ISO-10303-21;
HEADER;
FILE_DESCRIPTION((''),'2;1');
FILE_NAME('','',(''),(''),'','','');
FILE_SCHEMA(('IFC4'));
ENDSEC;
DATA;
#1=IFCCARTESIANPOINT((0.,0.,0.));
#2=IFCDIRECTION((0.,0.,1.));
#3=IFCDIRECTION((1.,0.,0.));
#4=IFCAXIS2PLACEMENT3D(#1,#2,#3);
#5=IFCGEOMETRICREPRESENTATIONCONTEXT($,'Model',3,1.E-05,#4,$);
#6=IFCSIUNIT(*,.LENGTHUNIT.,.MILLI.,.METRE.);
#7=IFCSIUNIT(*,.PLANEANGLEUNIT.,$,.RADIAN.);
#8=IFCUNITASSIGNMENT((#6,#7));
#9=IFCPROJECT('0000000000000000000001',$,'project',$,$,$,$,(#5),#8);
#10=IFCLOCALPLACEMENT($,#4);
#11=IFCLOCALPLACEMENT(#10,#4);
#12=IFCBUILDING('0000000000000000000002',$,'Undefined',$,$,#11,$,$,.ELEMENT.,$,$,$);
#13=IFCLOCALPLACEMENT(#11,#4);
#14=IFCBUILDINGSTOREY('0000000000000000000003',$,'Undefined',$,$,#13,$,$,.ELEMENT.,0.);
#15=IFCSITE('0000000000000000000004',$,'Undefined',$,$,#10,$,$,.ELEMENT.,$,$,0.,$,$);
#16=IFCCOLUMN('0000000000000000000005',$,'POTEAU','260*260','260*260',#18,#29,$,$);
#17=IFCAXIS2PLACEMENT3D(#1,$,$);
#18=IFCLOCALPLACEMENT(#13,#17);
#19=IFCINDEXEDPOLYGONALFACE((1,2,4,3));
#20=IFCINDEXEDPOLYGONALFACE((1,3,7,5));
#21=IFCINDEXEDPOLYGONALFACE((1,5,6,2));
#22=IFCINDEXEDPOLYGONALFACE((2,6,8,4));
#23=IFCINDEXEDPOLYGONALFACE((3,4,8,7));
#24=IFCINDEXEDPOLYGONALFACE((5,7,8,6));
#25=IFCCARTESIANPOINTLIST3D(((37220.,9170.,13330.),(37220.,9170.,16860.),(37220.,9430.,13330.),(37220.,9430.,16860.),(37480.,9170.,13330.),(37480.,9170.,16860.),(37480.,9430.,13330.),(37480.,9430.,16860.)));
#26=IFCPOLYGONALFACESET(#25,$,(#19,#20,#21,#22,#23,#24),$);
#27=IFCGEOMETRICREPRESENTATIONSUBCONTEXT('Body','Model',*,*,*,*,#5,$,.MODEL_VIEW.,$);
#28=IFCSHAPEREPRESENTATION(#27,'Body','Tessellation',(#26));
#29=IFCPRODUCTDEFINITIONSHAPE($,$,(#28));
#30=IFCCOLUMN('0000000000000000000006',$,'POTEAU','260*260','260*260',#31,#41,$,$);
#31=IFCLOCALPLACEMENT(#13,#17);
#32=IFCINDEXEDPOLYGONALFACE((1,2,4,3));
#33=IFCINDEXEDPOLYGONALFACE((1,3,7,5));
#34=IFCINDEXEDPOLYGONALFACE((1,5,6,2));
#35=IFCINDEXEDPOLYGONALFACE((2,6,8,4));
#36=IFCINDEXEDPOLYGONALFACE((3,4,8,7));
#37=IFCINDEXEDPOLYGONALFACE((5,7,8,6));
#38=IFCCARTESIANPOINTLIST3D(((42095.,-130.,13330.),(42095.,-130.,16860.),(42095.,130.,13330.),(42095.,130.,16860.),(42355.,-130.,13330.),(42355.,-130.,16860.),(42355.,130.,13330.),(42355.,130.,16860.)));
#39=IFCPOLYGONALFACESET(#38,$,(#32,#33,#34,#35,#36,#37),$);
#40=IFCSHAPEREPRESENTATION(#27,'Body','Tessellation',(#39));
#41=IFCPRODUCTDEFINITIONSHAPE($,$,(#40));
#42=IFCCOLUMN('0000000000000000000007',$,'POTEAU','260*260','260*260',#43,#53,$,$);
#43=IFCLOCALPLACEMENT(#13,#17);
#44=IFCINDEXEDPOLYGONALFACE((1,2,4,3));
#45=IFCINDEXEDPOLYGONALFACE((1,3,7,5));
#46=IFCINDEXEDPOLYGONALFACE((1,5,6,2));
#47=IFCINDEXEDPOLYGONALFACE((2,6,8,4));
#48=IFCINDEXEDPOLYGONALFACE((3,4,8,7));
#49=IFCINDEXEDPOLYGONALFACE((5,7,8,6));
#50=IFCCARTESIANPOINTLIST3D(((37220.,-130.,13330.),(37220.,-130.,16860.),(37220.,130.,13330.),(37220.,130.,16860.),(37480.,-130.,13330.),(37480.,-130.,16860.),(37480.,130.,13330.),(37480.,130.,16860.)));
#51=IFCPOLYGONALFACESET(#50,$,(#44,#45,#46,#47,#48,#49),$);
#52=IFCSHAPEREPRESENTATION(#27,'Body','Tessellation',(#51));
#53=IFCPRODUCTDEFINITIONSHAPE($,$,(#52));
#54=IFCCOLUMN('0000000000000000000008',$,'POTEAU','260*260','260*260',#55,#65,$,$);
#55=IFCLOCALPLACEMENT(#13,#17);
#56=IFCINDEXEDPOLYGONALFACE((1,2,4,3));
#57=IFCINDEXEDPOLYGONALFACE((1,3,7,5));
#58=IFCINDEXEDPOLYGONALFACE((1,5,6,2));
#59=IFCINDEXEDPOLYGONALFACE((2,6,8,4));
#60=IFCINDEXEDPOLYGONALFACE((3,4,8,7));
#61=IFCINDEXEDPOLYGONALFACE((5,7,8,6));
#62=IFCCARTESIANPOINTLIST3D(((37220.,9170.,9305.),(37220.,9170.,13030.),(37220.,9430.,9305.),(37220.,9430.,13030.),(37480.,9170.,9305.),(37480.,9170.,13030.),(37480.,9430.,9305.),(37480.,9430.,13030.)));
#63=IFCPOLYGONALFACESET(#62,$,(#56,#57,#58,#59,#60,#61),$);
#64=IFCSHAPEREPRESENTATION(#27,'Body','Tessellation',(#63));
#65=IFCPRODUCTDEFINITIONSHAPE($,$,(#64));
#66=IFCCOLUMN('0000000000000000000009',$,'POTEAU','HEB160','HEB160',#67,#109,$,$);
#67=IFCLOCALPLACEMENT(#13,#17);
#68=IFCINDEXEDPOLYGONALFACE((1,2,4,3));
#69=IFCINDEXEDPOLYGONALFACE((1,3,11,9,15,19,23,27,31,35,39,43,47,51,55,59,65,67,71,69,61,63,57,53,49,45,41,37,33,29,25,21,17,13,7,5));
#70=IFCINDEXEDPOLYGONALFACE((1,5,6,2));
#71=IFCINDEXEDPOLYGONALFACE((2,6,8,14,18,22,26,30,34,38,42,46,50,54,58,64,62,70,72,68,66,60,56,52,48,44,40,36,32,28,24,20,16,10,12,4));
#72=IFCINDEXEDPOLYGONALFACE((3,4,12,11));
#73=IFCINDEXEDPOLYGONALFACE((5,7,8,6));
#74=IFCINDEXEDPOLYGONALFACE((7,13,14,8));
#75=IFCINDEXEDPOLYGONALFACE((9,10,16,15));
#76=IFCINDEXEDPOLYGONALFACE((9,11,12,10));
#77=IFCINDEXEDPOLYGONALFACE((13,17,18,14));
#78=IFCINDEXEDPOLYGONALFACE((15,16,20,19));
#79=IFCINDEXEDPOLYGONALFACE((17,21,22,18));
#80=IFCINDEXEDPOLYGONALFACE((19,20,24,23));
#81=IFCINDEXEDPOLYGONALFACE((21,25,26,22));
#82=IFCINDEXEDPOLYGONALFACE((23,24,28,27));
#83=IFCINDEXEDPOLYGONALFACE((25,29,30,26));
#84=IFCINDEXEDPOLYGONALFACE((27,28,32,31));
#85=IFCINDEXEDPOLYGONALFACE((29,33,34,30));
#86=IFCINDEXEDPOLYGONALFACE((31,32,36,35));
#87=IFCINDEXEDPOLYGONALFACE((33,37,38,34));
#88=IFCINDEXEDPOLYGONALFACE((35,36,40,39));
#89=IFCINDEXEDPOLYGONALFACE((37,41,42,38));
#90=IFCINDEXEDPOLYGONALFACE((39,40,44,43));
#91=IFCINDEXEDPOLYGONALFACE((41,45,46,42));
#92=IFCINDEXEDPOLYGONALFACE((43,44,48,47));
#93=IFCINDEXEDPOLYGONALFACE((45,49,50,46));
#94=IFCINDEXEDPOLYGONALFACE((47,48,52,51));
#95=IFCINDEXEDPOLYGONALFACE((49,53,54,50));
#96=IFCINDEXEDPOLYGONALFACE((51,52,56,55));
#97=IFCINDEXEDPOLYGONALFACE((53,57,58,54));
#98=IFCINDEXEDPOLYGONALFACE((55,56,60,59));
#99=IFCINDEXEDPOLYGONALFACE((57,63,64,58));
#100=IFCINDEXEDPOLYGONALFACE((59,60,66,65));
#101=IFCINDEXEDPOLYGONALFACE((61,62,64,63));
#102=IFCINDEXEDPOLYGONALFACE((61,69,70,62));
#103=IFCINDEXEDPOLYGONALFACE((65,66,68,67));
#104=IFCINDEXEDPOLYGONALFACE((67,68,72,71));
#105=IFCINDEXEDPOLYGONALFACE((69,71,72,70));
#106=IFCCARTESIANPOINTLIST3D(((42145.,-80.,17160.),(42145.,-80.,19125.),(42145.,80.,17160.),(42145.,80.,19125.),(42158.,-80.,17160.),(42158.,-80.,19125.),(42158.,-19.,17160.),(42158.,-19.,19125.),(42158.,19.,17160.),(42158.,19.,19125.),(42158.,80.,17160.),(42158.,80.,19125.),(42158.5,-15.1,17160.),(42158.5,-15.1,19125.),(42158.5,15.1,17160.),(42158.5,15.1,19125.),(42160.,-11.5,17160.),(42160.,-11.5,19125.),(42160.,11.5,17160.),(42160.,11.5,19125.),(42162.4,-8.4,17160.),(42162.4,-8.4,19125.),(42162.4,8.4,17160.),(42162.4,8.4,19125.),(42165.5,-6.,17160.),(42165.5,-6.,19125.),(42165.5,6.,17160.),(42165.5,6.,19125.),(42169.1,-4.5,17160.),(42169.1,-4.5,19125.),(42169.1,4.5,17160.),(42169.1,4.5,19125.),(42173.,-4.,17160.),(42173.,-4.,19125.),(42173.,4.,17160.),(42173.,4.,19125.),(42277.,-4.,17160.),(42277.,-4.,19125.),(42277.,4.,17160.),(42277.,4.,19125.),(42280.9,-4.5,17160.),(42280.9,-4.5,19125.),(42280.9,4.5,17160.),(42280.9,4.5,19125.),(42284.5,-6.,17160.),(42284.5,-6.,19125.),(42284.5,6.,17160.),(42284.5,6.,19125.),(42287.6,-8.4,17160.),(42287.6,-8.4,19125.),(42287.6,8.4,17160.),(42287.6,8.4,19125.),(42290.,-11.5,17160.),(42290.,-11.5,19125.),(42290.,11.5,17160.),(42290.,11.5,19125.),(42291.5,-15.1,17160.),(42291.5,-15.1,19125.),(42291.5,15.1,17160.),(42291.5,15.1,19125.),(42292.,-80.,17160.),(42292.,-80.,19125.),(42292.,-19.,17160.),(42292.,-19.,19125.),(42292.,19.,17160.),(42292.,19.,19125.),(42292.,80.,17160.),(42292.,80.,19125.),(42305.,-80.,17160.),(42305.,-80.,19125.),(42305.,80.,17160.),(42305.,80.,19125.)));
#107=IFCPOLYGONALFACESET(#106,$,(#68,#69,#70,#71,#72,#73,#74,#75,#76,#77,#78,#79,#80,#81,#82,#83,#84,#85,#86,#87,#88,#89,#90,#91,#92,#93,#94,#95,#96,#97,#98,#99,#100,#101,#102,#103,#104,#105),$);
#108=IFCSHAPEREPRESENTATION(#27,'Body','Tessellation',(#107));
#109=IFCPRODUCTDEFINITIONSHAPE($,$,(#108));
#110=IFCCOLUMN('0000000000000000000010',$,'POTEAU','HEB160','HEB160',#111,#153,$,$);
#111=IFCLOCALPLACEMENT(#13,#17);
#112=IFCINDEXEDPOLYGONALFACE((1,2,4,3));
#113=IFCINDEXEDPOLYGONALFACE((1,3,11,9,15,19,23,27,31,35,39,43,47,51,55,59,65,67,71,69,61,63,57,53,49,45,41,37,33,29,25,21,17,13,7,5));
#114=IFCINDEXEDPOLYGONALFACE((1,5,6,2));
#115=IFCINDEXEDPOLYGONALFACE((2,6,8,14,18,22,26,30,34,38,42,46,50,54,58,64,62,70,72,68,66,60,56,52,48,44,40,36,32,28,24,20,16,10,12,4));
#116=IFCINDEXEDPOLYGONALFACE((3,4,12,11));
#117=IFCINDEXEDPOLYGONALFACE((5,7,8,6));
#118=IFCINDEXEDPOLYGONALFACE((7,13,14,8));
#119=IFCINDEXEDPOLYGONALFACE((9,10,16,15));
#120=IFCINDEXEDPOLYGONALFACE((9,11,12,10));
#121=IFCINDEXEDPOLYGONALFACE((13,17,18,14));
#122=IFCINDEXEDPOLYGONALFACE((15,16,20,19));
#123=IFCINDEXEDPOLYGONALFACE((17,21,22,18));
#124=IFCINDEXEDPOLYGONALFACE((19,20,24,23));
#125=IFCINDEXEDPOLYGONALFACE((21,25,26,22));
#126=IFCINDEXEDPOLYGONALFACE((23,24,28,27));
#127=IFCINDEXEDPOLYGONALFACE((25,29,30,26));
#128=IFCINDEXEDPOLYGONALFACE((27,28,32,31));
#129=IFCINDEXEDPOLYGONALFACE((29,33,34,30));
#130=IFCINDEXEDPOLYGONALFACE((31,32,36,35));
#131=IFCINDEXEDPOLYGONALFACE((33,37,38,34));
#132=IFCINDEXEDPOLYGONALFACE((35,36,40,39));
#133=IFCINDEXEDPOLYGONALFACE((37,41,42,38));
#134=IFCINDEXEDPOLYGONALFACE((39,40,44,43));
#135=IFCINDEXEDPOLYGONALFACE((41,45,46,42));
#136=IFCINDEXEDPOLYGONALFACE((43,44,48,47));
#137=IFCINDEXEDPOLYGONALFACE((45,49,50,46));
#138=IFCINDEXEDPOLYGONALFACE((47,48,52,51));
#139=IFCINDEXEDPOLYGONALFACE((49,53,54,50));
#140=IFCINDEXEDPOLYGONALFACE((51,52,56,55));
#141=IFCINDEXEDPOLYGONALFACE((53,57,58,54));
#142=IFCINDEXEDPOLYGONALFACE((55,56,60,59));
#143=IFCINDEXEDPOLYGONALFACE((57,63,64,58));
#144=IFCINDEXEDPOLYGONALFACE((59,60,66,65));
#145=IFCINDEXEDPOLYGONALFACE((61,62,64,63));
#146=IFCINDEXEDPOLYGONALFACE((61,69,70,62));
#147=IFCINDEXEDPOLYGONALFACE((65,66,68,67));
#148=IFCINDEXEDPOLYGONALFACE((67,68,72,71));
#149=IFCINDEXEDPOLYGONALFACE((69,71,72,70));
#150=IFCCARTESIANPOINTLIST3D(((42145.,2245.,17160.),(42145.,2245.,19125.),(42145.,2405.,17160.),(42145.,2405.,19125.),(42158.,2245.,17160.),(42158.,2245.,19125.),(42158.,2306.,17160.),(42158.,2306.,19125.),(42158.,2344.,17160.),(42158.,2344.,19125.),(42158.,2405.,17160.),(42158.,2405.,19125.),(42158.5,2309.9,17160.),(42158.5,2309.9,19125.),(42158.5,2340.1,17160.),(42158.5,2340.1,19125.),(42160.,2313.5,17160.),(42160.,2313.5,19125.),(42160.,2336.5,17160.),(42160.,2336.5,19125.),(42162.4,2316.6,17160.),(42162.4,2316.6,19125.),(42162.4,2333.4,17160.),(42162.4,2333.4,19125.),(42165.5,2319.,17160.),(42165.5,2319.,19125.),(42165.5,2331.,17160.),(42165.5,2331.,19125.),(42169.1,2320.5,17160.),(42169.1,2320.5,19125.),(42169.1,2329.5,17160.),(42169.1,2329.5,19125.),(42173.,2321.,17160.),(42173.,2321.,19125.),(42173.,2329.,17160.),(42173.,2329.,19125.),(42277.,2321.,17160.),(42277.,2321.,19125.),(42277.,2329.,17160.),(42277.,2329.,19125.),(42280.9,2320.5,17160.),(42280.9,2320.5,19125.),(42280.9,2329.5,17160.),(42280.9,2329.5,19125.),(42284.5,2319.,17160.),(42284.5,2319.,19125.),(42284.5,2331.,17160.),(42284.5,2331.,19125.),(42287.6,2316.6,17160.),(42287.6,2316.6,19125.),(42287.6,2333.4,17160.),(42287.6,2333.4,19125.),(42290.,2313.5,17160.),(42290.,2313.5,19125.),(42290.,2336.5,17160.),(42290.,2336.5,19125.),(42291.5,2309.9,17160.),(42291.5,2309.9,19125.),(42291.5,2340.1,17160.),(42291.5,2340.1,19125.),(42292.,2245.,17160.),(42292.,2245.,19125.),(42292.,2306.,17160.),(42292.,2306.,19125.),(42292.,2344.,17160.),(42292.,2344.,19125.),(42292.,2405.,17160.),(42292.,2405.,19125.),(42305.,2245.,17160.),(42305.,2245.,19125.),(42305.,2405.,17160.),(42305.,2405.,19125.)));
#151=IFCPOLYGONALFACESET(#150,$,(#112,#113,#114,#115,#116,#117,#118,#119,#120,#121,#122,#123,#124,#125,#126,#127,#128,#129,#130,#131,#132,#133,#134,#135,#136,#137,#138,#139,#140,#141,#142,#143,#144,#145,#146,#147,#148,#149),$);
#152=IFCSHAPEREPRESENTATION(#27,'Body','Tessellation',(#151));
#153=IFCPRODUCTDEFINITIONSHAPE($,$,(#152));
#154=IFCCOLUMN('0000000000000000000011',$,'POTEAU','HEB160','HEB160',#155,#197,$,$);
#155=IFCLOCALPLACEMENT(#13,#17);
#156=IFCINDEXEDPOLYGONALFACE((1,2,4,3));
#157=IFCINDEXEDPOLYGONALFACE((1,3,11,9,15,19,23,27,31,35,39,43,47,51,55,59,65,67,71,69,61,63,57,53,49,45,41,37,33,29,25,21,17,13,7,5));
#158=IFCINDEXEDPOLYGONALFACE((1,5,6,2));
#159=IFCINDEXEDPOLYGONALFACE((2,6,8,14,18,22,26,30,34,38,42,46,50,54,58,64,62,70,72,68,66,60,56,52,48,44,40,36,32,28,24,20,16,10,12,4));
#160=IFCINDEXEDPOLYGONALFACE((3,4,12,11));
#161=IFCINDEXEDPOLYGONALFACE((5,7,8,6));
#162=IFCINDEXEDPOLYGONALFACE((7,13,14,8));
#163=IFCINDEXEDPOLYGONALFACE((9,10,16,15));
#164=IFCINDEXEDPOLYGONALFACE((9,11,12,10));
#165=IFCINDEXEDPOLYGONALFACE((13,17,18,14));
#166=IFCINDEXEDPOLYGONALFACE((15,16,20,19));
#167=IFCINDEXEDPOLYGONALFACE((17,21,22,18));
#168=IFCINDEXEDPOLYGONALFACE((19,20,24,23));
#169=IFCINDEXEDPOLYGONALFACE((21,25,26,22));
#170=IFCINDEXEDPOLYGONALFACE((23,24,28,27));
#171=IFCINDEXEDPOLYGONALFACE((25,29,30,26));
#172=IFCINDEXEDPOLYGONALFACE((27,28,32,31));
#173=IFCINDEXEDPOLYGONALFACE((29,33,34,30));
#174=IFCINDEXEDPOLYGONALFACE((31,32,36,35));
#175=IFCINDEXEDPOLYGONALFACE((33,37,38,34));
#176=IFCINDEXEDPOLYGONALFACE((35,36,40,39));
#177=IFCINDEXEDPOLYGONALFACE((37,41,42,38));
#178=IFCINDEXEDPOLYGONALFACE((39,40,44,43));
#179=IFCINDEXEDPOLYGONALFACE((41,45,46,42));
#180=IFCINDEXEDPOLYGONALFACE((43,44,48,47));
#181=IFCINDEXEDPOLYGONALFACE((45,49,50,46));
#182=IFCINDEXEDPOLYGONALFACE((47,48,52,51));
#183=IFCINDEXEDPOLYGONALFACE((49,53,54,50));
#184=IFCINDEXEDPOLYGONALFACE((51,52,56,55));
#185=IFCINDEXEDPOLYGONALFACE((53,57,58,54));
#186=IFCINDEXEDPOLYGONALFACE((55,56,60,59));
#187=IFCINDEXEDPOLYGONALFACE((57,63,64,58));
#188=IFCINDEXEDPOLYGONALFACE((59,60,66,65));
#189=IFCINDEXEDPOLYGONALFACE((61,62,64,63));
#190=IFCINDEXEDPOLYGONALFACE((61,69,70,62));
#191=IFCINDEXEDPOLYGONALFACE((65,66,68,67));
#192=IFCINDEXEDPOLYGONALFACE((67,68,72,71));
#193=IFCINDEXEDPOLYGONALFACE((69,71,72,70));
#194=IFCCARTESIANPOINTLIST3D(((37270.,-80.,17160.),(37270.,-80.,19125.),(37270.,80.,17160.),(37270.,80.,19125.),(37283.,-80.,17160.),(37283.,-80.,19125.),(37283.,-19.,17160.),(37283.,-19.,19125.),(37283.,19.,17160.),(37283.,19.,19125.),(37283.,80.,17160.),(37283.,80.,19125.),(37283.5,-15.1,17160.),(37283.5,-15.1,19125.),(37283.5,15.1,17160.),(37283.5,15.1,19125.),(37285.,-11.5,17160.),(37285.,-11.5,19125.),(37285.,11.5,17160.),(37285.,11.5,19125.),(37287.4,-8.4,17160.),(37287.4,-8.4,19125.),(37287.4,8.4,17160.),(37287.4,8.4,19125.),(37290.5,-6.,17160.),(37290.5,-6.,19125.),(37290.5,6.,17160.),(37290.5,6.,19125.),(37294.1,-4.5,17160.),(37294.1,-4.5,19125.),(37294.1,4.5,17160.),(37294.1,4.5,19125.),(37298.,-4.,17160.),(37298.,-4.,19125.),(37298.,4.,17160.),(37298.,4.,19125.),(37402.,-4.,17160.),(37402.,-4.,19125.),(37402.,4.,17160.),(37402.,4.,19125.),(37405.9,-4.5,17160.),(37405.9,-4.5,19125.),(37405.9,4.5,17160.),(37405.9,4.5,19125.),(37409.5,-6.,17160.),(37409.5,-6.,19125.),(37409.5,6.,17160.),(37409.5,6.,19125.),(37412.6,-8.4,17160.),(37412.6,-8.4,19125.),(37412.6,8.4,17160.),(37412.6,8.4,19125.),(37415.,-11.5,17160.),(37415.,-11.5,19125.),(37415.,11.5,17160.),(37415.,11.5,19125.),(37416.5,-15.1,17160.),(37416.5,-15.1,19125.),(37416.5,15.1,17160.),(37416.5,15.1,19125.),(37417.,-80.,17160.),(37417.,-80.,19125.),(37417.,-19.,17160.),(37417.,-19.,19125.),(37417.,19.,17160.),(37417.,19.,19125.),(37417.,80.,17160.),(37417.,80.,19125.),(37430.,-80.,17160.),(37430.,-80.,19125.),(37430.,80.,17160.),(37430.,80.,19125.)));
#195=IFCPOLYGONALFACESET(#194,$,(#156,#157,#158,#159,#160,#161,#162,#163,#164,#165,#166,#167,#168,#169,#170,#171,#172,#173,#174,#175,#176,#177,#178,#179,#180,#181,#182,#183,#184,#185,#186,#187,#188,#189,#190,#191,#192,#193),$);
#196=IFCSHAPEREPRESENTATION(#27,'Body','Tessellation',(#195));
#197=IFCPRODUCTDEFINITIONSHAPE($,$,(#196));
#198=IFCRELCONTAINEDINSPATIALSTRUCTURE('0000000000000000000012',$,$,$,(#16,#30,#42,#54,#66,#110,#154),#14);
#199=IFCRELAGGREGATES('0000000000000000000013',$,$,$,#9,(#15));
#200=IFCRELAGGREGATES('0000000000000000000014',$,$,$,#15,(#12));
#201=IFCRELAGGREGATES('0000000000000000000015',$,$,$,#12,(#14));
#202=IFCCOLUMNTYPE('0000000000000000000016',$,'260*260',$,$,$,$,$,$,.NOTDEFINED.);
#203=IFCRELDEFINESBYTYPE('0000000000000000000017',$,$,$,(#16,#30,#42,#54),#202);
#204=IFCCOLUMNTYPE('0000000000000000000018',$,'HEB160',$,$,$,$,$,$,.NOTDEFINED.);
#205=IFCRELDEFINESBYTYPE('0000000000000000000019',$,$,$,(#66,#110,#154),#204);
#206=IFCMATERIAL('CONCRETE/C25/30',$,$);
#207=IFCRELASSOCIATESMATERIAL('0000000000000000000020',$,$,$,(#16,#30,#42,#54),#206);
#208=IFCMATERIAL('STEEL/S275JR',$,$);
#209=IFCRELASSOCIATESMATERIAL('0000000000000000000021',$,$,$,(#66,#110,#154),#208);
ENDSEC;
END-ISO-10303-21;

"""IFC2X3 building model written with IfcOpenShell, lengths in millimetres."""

from ifc_helpers import new_model, si_unit, frame, origin_with_axes, origin_2d_with_axis, place, context, subcontext, project, spatial, rectangle, i_section, extrude, material, type_object, element, save


model = new_model("IFC2X3")

# Units and contexts
model_context = context("Model", 3, precision=1e-05, world=origin_with_axes())
body_context = subcontext(model_context, "Body", "Model", "MODEL_VIEW")
ifc_project = project(units=[si_unit("LENGTHUNIT", "METRE", prefix="MILLI"), si_unit("PLANEANGLEUNIT", "RADIAN")], contexts=[model_context])

# Site, building, storey
site_placement = place(None, origin_with_axes())
site = spatial("IfcSite", under=ifc_project, at=site_placement, Name="Undefined", CompositionType="ELEMENT", RefElevation=0.0)
building_placement = place(site_placement, origin_with_axes())
building = spatial("IfcBuilding", under=site, at=building_placement, Name="Undefined", CompositionType="ELEMENT")
storey_placement = place(building_placement, origin_with_axes())
storey = spatial("IfcBuildingStorey", under=building, at=storey_placement, Name="Undefined", CompositionType="ELEMENT", Elevation=0.0)

# Columns
ifc_material_1 = material(Name="CONCRETE/C25/30")
column_type_1 = type_object("IfcColumnType", Name="260*260", PredefinedType="NOTDEFINED")
for number, where, z_axis, x_axis, name in (
    (1, (37350.0, 9300.0, 13330.0), (0.0, 0.0, 1.0), (1.0, 0.0, 0.0), "POTEAU"),
    (2, (42225.0, 0.0, 13330.0), (0.0, 0.0, 1.0), (1.0, 0.0, 0.0), "POTEAU"),
    (3, (37350.0, 0.0, 13330.0), (0.0, 0.0, 1.0), (1.0, 0.0, 0.0), "POTEAU"),
):
    element("IfcColumn", number, at=place(storey_placement, frame(where, z_axis=z_axis, x_axis=x_axis)), inside=storey, type_object=column_type_1, material=ifc_material_1, Name=name, Description="260*260", ObjectType="260*260", context=body_context, shape_type="SweptSolid", body=[
        extrude(rectangle(XDim=260.0, YDim=260.0, at=origin_2d_with_axis()), frame((0.0, 0.0, 3530.0), z_axis=(0.0, 0.0, -1.0), x_axis=(-1.0, 0.0, 0.0)), (0.0, 0.0, 1.0), 3530.0),
    ])
column_1_placement = place(storey_placement, frame((37350.0, 9300.0, 9305.0), z_axis=(0.0, 0.0, 1.0), x_axis=(1.0, 0.0, 0.0)))
element("IfcColumn", 4, at=column_1_placement, inside=storey, type_object=column_type_1, material=ifc_material_1, Name="POTEAU", Description="260*260", ObjectType="260*260", context=body_context, shape_type="SweptSolid", body=[
    extrude(rectangle(XDim=260.0, YDim=260.0, at=origin_2d_with_axis()), frame((0.0, 0.0, 3725.0), z_axis=(0.0, 0.0, -1.0), x_axis=(-1.0, 0.0, 0.0)), (0.0, 0.0, 1.0), 3725.0),
])
ifc_material_2 = material(Name="STEEL/S275JR")
column_type_2 = type_object("IfcColumnType", Name="HEB160", PredefinedType="NOTDEFINED")
for number, where, z_axis, x_axis, name in (
    (5, (42225.0, 0.0, 17160.0), (0.0, 0.0, 1.0), (1.0, 0.0, 0.0), "POTEAU"),
    (6, (42225.0, 2325.0, 17160.0), (0.0, 0.0, 1.0), (1.0, 0.0, 0.0), "POTEAU"),
    (7, (37350.0, 0.0, 17160.0), (0.0, 0.0, 1.0), (1.0, 0.0, 0.0), "POTEAU"),
):
    element("IfcColumn", number, at=place(storey_placement, frame(where, z_axis=z_axis, x_axis=x_axis)), inside=storey, type_object=column_type_2, material=ifc_material_2, Name=name, Description="HEB160", ObjectType="HEB160", context=body_context, shape_type="SweptSolid", body=[
        extrude(i_section(OverallWidth=160.0, OverallDepth=160.0, WebThickness=8.0, FlangeThickness=13.0, FilletRadius=15.0, at=origin_2d_with_axis()), frame((0.0, 0.0, 1965.0), z_axis=(0.0, 0.0, -1.0), x_axis=(0.0, -1.0, 0.0)), (0.0, 0.0, 1.0), 1965.0),
    ])

save(model, "model.ifc")
